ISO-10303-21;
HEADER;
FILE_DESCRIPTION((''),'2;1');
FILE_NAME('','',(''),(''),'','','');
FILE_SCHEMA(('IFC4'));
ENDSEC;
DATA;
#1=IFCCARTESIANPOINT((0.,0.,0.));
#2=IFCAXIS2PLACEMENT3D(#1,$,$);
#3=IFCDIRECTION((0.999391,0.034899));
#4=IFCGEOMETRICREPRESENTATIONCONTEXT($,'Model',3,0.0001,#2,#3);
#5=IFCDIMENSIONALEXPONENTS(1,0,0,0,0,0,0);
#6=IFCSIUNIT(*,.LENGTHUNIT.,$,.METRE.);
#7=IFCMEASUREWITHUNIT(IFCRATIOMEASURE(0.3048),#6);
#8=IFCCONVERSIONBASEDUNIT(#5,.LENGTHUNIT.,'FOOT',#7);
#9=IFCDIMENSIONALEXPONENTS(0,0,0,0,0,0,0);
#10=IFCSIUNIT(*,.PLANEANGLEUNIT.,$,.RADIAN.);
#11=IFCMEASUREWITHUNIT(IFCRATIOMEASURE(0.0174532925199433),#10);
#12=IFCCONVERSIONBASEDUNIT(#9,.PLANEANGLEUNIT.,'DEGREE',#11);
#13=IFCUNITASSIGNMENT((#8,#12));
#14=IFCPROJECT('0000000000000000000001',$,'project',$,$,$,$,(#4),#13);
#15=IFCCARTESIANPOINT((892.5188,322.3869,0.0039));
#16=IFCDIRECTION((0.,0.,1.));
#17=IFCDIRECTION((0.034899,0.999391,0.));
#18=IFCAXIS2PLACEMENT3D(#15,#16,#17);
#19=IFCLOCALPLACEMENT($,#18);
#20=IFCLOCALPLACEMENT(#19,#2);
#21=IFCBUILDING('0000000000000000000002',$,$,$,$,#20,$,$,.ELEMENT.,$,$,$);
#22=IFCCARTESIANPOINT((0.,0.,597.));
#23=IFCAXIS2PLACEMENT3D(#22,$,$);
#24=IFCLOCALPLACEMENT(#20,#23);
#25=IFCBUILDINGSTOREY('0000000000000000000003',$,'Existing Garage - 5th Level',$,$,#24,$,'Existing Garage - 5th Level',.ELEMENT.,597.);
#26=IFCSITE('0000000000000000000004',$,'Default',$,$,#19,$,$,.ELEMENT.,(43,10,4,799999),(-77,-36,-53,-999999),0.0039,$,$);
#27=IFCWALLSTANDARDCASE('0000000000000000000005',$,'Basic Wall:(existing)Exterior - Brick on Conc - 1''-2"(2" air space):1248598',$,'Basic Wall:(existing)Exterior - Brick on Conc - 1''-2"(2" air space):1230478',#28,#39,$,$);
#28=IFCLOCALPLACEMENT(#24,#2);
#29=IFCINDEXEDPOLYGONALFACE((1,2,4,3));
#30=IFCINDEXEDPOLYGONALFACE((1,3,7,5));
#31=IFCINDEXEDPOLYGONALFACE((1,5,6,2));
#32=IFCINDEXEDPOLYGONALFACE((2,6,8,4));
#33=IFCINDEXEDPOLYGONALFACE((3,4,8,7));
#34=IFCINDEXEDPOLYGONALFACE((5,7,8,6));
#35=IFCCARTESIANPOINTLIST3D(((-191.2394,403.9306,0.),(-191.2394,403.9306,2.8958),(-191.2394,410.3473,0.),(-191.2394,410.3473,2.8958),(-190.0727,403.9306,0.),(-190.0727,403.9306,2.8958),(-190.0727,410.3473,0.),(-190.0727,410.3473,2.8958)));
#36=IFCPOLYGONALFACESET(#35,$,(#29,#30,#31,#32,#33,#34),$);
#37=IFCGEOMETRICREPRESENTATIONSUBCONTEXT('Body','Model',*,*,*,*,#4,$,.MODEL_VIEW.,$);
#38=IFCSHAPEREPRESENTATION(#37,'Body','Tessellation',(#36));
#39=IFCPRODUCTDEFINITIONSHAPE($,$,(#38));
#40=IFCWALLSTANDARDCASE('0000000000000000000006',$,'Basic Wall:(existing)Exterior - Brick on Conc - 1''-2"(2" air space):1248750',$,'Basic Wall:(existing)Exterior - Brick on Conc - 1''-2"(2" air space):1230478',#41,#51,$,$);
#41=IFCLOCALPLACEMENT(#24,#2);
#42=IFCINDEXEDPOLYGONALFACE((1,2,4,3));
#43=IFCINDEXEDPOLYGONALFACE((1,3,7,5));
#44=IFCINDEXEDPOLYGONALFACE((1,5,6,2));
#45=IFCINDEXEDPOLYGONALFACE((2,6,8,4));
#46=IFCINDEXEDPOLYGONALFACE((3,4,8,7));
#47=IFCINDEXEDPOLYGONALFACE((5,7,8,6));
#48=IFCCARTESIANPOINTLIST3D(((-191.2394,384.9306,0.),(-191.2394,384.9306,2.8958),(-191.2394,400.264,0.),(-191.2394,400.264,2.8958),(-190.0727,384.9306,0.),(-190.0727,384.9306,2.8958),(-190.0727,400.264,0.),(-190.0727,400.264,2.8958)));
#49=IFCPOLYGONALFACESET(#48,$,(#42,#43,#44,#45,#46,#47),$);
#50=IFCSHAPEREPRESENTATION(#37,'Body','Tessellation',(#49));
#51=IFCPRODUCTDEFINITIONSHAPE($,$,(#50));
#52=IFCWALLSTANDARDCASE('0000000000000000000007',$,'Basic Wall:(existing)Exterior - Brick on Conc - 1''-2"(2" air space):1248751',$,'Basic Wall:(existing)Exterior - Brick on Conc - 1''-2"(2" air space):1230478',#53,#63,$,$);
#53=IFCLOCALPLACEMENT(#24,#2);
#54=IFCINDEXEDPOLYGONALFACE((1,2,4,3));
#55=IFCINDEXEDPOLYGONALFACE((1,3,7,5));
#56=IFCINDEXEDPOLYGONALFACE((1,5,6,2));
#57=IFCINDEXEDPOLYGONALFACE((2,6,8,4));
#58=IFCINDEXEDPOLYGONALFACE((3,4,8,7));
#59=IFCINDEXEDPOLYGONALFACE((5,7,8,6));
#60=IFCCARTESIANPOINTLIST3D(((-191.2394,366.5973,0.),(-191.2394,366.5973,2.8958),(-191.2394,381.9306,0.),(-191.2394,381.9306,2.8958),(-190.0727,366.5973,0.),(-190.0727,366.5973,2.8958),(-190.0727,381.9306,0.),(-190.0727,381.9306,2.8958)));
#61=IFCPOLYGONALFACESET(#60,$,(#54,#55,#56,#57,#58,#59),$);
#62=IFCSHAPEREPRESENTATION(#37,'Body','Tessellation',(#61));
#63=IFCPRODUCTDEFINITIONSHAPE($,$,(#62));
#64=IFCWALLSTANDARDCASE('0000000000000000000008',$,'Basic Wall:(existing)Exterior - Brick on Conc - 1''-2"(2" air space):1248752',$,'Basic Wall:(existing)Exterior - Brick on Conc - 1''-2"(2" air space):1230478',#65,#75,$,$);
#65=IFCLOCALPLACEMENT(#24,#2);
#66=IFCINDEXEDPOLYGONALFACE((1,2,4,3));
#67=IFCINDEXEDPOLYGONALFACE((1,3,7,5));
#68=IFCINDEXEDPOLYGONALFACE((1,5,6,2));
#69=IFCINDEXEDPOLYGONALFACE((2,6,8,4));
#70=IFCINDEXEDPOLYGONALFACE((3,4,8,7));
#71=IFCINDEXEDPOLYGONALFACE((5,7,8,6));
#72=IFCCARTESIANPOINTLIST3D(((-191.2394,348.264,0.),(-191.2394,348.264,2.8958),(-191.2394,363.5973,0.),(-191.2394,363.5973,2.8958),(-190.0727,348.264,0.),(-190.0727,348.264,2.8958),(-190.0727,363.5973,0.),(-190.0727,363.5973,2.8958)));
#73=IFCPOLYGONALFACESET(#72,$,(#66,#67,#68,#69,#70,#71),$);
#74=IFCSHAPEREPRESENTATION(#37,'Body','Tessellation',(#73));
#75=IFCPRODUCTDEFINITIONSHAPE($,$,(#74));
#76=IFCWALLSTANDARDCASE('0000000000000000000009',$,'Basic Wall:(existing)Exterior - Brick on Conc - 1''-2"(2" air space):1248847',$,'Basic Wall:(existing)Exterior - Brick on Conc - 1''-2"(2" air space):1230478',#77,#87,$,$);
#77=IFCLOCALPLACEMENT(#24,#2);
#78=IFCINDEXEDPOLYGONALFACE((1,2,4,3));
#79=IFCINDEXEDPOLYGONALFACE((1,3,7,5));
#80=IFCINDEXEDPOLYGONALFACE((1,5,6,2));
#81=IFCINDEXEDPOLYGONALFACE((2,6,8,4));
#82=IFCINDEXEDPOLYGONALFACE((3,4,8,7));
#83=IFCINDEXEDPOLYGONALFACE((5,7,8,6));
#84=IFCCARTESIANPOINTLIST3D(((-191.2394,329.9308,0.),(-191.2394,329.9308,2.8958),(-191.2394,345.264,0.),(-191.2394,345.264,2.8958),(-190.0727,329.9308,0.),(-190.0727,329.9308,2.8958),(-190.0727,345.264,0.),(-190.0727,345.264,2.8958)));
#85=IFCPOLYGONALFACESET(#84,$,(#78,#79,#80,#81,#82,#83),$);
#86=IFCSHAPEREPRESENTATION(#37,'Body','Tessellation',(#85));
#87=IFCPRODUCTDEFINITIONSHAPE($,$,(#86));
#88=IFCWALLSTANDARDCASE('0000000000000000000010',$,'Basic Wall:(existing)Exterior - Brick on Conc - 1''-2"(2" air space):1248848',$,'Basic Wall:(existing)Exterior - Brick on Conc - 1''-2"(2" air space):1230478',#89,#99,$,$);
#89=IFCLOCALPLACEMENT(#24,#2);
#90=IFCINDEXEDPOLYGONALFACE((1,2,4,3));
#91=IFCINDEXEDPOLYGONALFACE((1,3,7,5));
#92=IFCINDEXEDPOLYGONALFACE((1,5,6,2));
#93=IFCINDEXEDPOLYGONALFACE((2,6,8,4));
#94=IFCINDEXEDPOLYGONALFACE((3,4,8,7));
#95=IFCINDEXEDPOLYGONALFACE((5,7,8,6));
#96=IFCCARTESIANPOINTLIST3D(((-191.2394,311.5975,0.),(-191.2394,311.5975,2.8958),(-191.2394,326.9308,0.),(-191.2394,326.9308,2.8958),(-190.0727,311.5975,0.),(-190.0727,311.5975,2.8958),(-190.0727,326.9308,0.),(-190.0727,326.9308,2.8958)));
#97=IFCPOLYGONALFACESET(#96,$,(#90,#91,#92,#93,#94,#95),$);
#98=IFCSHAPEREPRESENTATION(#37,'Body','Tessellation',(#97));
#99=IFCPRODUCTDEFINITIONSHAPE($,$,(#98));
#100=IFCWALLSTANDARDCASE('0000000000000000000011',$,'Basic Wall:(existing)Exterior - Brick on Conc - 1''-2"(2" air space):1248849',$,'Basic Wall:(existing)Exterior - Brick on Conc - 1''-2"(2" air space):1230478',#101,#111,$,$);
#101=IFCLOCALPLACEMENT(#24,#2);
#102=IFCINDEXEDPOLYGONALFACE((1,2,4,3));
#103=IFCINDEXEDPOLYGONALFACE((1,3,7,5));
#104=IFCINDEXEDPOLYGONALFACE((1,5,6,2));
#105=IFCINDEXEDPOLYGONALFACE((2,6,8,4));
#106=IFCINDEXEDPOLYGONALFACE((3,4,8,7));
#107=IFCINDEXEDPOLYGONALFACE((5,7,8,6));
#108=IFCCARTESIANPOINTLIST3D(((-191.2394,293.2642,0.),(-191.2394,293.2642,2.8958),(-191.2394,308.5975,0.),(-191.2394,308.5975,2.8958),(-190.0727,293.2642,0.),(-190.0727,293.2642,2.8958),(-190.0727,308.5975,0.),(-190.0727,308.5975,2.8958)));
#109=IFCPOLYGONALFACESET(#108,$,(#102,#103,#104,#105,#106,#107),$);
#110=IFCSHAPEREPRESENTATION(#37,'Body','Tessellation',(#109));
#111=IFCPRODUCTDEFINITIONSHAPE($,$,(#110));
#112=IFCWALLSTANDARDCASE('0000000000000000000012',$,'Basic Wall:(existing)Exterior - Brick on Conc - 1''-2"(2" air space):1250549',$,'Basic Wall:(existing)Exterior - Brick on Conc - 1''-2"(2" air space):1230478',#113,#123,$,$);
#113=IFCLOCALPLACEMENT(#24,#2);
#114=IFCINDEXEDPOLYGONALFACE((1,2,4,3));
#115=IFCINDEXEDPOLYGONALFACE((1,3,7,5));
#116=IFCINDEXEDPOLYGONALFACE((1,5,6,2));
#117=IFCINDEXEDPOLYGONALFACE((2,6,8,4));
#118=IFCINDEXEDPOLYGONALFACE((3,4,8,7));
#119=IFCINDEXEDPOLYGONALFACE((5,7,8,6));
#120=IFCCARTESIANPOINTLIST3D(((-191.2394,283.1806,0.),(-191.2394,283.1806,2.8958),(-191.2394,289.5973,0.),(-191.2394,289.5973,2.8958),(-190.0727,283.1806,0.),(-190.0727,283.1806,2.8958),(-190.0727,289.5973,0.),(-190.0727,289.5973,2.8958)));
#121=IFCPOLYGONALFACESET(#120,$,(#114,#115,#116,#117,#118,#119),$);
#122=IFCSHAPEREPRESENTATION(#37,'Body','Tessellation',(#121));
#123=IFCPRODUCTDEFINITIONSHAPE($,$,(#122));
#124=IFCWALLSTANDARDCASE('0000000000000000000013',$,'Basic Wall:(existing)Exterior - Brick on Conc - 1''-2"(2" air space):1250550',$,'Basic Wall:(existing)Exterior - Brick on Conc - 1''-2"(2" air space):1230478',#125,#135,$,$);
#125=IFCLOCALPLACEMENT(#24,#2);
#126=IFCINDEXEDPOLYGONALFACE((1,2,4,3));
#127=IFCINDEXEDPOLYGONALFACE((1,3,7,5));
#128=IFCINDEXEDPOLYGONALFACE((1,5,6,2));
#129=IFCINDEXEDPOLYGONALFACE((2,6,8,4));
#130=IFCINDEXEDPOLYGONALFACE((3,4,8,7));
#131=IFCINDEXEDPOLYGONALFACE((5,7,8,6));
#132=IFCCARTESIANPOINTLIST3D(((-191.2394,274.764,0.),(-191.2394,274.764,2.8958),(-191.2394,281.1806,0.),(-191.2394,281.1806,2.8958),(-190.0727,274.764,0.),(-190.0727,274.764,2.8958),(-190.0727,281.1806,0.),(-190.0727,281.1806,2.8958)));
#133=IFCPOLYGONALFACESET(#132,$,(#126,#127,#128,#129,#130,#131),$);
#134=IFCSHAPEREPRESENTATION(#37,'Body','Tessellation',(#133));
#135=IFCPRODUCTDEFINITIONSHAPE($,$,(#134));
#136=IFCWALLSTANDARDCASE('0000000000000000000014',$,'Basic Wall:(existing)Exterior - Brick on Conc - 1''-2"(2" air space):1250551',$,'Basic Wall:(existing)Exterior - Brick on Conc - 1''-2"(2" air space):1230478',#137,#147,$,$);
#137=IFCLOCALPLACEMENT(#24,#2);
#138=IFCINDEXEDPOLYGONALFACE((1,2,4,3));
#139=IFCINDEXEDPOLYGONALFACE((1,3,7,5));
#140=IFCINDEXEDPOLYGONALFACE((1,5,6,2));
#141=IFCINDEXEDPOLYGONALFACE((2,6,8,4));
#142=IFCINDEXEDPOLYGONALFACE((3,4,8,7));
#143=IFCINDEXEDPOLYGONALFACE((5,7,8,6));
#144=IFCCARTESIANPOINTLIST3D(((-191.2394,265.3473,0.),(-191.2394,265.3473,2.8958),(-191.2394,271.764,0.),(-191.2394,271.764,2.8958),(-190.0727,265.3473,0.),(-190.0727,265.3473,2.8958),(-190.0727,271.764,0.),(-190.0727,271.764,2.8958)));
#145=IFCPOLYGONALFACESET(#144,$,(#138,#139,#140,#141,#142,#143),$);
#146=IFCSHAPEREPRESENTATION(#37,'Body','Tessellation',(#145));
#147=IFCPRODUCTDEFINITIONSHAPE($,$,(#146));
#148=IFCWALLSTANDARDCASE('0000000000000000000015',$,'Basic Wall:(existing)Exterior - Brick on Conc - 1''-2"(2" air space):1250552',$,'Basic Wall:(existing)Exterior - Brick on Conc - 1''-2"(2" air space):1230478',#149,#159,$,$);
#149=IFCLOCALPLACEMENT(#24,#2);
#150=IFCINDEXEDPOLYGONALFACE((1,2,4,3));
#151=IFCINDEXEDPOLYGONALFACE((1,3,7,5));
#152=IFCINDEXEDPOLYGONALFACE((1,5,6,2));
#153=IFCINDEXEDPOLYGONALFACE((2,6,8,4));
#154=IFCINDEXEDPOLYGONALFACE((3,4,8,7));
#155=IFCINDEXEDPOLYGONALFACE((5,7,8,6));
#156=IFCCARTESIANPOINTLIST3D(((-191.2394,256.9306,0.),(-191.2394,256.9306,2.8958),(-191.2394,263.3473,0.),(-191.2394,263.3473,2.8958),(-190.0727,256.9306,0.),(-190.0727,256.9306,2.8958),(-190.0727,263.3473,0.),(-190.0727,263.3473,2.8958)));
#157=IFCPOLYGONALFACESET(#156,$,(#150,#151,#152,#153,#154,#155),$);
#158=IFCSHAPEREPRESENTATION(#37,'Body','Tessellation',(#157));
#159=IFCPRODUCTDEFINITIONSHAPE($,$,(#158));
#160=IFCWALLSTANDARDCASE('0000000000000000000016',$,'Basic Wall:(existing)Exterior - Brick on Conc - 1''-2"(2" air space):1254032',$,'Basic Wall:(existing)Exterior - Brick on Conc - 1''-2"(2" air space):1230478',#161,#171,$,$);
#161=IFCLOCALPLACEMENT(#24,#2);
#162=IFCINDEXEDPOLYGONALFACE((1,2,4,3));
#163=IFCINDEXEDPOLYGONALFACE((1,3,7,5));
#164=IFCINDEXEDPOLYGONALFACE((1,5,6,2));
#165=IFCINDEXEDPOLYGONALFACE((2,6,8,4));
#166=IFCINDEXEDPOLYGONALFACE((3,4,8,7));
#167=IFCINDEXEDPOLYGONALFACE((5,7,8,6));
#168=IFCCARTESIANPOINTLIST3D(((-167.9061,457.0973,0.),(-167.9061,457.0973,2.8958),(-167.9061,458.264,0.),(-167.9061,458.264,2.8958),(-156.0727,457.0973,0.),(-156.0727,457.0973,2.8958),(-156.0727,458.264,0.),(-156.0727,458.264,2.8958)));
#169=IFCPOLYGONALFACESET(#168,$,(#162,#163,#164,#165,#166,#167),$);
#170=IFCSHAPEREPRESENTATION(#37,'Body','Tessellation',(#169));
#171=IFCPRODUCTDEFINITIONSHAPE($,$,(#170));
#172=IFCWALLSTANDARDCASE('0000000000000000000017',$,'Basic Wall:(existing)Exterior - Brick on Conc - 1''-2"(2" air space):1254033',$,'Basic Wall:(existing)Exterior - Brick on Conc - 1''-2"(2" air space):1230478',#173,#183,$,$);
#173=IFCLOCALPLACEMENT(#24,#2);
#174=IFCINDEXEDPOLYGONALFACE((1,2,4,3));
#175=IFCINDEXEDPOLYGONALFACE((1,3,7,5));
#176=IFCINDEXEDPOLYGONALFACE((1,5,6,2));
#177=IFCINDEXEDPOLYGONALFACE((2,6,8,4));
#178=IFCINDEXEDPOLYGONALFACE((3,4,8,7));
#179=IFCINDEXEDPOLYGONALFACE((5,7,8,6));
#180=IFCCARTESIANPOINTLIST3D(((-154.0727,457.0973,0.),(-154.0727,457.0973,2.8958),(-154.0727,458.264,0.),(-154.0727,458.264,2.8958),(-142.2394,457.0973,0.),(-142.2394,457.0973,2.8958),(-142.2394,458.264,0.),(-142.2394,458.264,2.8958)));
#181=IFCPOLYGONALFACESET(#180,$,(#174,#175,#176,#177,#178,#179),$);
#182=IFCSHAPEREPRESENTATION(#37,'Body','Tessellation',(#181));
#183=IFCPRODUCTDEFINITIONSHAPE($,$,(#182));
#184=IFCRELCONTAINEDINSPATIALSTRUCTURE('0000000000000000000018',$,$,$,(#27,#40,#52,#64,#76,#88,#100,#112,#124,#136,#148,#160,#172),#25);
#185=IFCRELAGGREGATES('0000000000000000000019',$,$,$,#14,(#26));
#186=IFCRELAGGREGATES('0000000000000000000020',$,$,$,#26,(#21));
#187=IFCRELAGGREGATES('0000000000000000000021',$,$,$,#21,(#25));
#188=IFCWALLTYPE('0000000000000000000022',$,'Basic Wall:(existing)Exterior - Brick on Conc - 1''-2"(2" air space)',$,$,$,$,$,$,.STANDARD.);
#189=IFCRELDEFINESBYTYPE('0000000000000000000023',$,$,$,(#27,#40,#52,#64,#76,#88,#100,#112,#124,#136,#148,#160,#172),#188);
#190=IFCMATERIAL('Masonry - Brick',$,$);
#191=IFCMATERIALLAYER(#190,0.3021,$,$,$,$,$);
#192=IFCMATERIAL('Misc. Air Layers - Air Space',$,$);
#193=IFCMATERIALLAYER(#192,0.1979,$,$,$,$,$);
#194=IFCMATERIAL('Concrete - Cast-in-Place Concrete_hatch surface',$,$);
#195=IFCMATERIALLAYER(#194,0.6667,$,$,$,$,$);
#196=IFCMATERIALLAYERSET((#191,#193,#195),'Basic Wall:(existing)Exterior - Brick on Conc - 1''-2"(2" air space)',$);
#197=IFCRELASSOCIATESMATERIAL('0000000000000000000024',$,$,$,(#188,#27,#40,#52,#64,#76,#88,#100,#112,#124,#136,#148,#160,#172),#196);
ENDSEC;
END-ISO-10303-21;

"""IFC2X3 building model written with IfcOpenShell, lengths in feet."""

from ifc_helpers import new_model, entity, si_unit, converted_unit, direction, frame, frame_2d, origin, place, context, subcontext, project, spatial, rectangle, extrude, material, layer, layer_set, layer_usage, type_object, element, save


model = new_model("IFC2X3")

# Units and contexts
model_context = context("Model", 3, precision=0.0001, world=origin(), true_north=direction((0.999391, 0.034899)))
body_context = subcontext(model_context, "Body", "Model", "MODEL_VIEW")
ifc_project = project(units=[converted_unit("LENGTHUNIT", "FOOT", entity("IfcRatioMeasure", 0.3048), si_unit("LENGTHUNIT", "METRE"), dimensions=[1, 0, 0, 0, 0, 0, 0]), converted_unit("PLANEANGLEUNIT", "DEGREE", entity("IfcRatioMeasure", 0.0174532925199433), si_unit("PLANEANGLEUNIT", "RADIAN"), dimensions=[0, 0, 0, 0, 0, 0, 0])], contexts=[model_context])

# Site, building, storey
site_placement = place(None, frame((892.5188, 322.3869, 0.0039), z_axis=(0.0, 0.0, 1.0), x_axis=(0.034899, 0.999391, 0.0)))
site = spatial("IfcSite", under=ifc_project, at=site_placement, Name="Default", CompositionType="ELEMENT", RefLatitude=(43, 10, 4, 799999), RefLongitude=(-77, -36, -53, -999999), RefElevation=0.0039)
building_placement = place(site_placement, origin())
building = spatial("IfcBuilding", under=site, at=building_placement, CompositionType="ELEMENT")
storey_placement = place(building_placement, frame((0.0, 0.0, 597.0)))
storey = spatial("IfcBuildingStorey", under=building, at=storey_placement, Name="Existing Garage - 5th Level", LongName="Existing Garage - 5th Level", CompositionType="ELEMENT", Elevation=597.0)

# Walls
ifc_material_1 = material(Name="Masonry - Brick")
ifc_layer_1 = layer(ifc_material_1, 0.3021)
ifc_material_2 = material(Name="Misc. Air Layers - Air Space")
ifc_layer_2 = layer(ifc_material_2, 0.1979)
ifc_material_3 = material(Name="Concrete - Cast-in-Place Concrete_hatch surface")
ifc_layer_3 = layer(ifc_material_3, 0.6667)
ifc_layer_set_1 = layer_set([ifc_layer_1, ifc_layer_2, ifc_layer_3], Name="Basic Wall:(existing)Exterior - Brick on Conc - 1'-2\"(2\" air space)")
wall_type_1 = type_object("IfcWallType", Name="Basic Wall:(existing)Exterior - Brick on Conc - 1'-2\"(2\" air space)", PredefinedType="STANDARD", material=ifc_layer_set_1)
ifc_layer_usage_1 = layer_usage(ifc_layer_set_1, "AXIS2", "POSITIVE", -0.5833)
wall_1_placement = place(storey_placement, frame((-190.6561, 410.3473, 0.0), z_axis=(0.0, 0.0, 1.0), x_axis=(0.0, -1.0, 0.0)))
element("IfcWallStandardCase", 1, at=wall_1_placement, inside=storey, type_object=wall_type_1, material=ifc_layer_usage_1, Name="Basic Wall:(existing)Exterior - Brick on Conc - 1'-2\"(2\" air space):1248598", ObjectType="Basic Wall:(existing)Exterior - Brick on Conc - 1'-2\"(2\" air space):1230478", context=body_context, shape_type="SweptSolid", body=[
    extrude(rectangle(XDim=6.4167, YDim=1.1667, at=frame_2d((3.2084, 0.0), x_axis=(-1.0, 0.0))), origin(), (0.0, 0.0, 1.0), 2.8958),
])
ifc_layer_usage_2 = layer_usage(ifc_layer_set_1, "AXIS2", "POSITIVE", -0.5833)
wall_2_placement = place(storey_placement, frame((-190.6561, 400.264, 0.0), z_axis=(0.0, 0.0, 1.0), x_axis=(0.0, -1.0, 0.0)))
element("IfcWallStandardCase", 2, at=wall_2_placement, inside=storey, type_object=wall_type_1, material=ifc_layer_usage_2, Name="Basic Wall:(existing)Exterior - Brick on Conc - 1'-2\"(2\" air space):1248750", ObjectType="Basic Wall:(existing)Exterior - Brick on Conc - 1'-2\"(2\" air space):1230478", context=body_context, shape_type="SweptSolid", body=[
    extrude(rectangle(XDim=15.3333, YDim=1.1667, at=frame_2d((7.6667, 0.0), x_axis=(-1.0, 0.0))), origin(), (0.0, 0.0, 1.0), 2.8958),
])
ifc_layer_usage_3 = layer_usage(ifc_layer_set_1, "AXIS2", "POSITIVE", -0.5833)
wall_3_placement = place(storey_placement, frame((-190.6561, 381.9306, 0.0), z_axis=(0.0, 0.0, 1.0), x_axis=(0.0, -1.0, 0.0)))
element("IfcWallStandardCase", 3, at=wall_3_placement, inside=storey, type_object=wall_type_1, material=ifc_layer_usage_3, Name="Basic Wall:(existing)Exterior - Brick on Conc - 1'-2\"(2\" air space):1248751", ObjectType="Basic Wall:(existing)Exterior - Brick on Conc - 1'-2\"(2\" air space):1230478", context=body_context, shape_type="SweptSolid", body=[
    extrude(rectangle(XDim=15.3333, YDim=1.1667, at=frame_2d((7.6667, 0.0), x_axis=(-1.0, 0.0))), origin(), (0.0, 0.0, 1.0), 2.8958),
])
ifc_layer_usage_4 = layer_usage(ifc_layer_set_1, "AXIS2", "POSITIVE", -0.5833)
wall_4_placement = place(storey_placement, frame((-190.6561, 363.5973, 0.0), z_axis=(0.0, 0.0, 1.0), x_axis=(0.0, -1.0, 0.0)))
element("IfcWallStandardCase", 4, at=wall_4_placement, inside=storey, type_object=wall_type_1, material=ifc_layer_usage_4, Name="Basic Wall:(existing)Exterior - Brick on Conc - 1'-2\"(2\" air space):1248752", ObjectType="Basic Wall:(existing)Exterior - Brick on Conc - 1'-2\"(2\" air space):1230478", context=body_context, shape_type="SweptSolid", body=[
    extrude(rectangle(XDim=15.3333, YDim=1.1667, at=frame_2d((7.6667, 0.0), x_axis=(-1.0, 0.0))), origin(), (0.0, 0.0, 1.0), 2.8958),
])
ifc_layer_usage_5 = layer_usage(ifc_layer_set_1, "AXIS2", "POSITIVE", -0.5833)
wall_5_placement = place(storey_placement, frame((-190.6561, 345.264, 0.0), z_axis=(0.0, 0.0, 1.0), x_axis=(0.0, -1.0, 0.0)))
element("IfcWallStandardCase", 5, at=wall_5_placement, inside=storey, type_object=wall_type_1, material=ifc_layer_usage_5, Name="Basic Wall:(existing)Exterior - Brick on Conc - 1'-2\"(2\" air space):1248847", ObjectType="Basic Wall:(existing)Exterior - Brick on Conc - 1'-2\"(2\" air space):1230478", context=body_context, shape_type="SweptSolid", body=[
    extrude(rectangle(XDim=15.3331, YDim=1.1667, at=frame_2d((7.6666, 0.0), x_axis=(-1.0, 0.0))), origin(), (0.0, 0.0, 1.0), 2.8958),
])
ifc_layer_usage_6 = layer_usage(ifc_layer_set_1, "AXIS2", "POSITIVE", -0.5833)
wall_6_placement = place(storey_placement, frame((-190.6561, 326.9308, 0.0), z_axis=(0.0, 0.0, 1.0), x_axis=(0.0, -1.0, 0.0)))
element("IfcWallStandardCase", 6, at=wall_6_placement, inside=storey, type_object=wall_type_1, material=ifc_layer_usage_6, Name="Basic Wall:(existing)Exterior - Brick on Conc - 1'-2\"(2\" air space):1248848", ObjectType="Basic Wall:(existing)Exterior - Brick on Conc - 1'-2\"(2\" air space):1230478", context=body_context, shape_type="SweptSolid", body=[
    extrude(rectangle(XDim=15.3333, YDim=1.1667, at=frame_2d((7.6667, 0.0), x_axis=(-1.0, 0.0))), origin(), (0.0, 0.0, 1.0), 2.8958),
])
ifc_layer_usage_7 = layer_usage(ifc_layer_set_1, "AXIS2", "POSITIVE", -0.5833)
wall_7_placement = place(storey_placement, frame((-190.6561, 308.5975, 0.0), z_axis=(0.0, 0.0, 1.0), x_axis=(0.0, -1.0, 0.0)))
element("IfcWallStandardCase", 7, at=wall_7_placement, inside=storey, type_object=wall_type_1, material=ifc_layer_usage_7, Name="Basic Wall:(existing)Exterior - Brick on Conc - 1'-2\"(2\" air space):1248849", ObjectType="Basic Wall:(existing)Exterior - Brick on Conc - 1'-2\"(2\" air space):1230478", context=body_context, shape_type="SweptSolid", body=[
    extrude(rectangle(XDim=15.3333, YDim=1.1667, at=frame_2d((7.6667, 0.0), x_axis=(-1.0, 0.0))), origin(), (0.0, 0.0, 1.0), 2.8958),
])
ifc_layer_usage_8 = layer_usage(ifc_layer_set_1, "AXIS2", "POSITIVE", -0.5833)
wall_8_placement = place(storey_placement, frame((-190.6561, 289.5973, 0.0), z_axis=(0.0, 0.0, 1.0), x_axis=(0.0, -1.0, 0.0)))
element("IfcWallStandardCase", 8, at=wall_8_placement, inside=storey, type_object=wall_type_1, material=ifc_layer_usage_8, Name="Basic Wall:(existing)Exterior - Brick on Conc - 1'-2\"(2\" air space):1250549", ObjectType="Basic Wall:(existing)Exterior - Brick on Conc - 1'-2\"(2\" air space):1230478", context=body_context, shape_type="SweptSolid", body=[
    extrude(rectangle(XDim=6.4167, YDim=1.1667, at=frame_2d((3.2083, 0.0), x_axis=(-1.0, 0.0))), origin(), (0.0, 0.0, 1.0), 2.8958),
])
ifc_layer_usage_9 = layer_usage(ifc_layer_set_1, "AXIS2", "POSITIVE", -0.5833)
wall_9_placement = place(storey_placement, frame((-190.6561, 281.1806, 0.0), z_axis=(0.0, 0.0, 1.0), x_axis=(0.0, -1.0, 0.0)))
element("IfcWallStandardCase", 9, at=wall_9_placement, inside=storey, type_object=wall_type_1, material=ifc_layer_usage_9, Name="Basic Wall:(existing)Exterior - Brick on Conc - 1'-2\"(2\" air space):1250550", ObjectType="Basic Wall:(existing)Exterior - Brick on Conc - 1'-2\"(2\" air space):1230478", context=body_context, shape_type="SweptSolid", body=[
    extrude(rectangle(XDim=6.4167, YDim=1.1667, at=frame_2d((3.2083, 0.0), x_axis=(-1.0, 0.0))), origin(), (0.0, 0.0, 1.0), 2.8958),
])
ifc_layer_usage_10 = layer_usage(ifc_layer_set_1, "AXIS2", "POSITIVE", -0.5833)
wall_10_placement = place(storey_placement, frame((-190.6561, 271.764, 0.0), z_axis=(0.0, 0.0, 1.0), x_axis=(0.0, -1.0, 0.0)))
element("IfcWallStandardCase", 10, at=wall_10_placement, inside=storey, type_object=wall_type_1, material=ifc_layer_usage_10, Name="Basic Wall:(existing)Exterior - Brick on Conc - 1'-2\"(2\" air space):1250551", ObjectType="Basic Wall:(existing)Exterior - Brick on Conc - 1'-2\"(2\" air space):1230478", context=body_context, shape_type="SweptSolid", body=[
    extrude(rectangle(XDim=6.4167, YDim=1.1667, at=frame_2d((3.2083, 0.0), x_axis=(-1.0, 0.0))), origin(), (0.0, 0.0, 1.0), 2.8958),
])
ifc_layer_usage_11 = layer_usage(ifc_layer_set_1, "AXIS2", "POSITIVE", -0.5833)
wall_11_placement = place(storey_placement, frame((-190.6561, 263.3473, 0.0), z_axis=(0.0, 0.0, 1.0), x_axis=(0.0, -1.0, 0.0)))
element("IfcWallStandardCase", 11, at=wall_11_placement, inside=storey, type_object=wall_type_1, material=ifc_layer_usage_11, Name="Basic Wall:(existing)Exterior - Brick on Conc - 1'-2\"(2\" air space):1250552", ObjectType="Basic Wall:(existing)Exterior - Brick on Conc - 1'-2\"(2\" air space):1230478", context=body_context, shape_type="SweptSolid", body=[
    extrude(rectangle(XDim=6.4167, YDim=1.1667, at=frame_2d((3.2083, 0.0), x_axis=(-1.0, 0.0))), origin(), (0.0, 0.0, 1.0), 2.8958),
])
ifc_layer_usage_12 = layer_usage(ifc_layer_set_1, "AXIS2", "POSITIVE", -0.5833)
wall_12_placement = place(storey_placement, frame((-156.0727, 457.6806, 0.0), z_axis=(0.0, 0.0, 1.0), x_axis=(-1.0, 0.0, 0.0)))
element("IfcWallStandardCase", 12, at=wall_12_placement, inside=storey, type_object=wall_type_1, material=ifc_layer_usage_12, Name="Basic Wall:(existing)Exterior - Brick on Conc - 1'-2\"(2\" air space):1254032", ObjectType="Basic Wall:(existing)Exterior - Brick on Conc - 1'-2\"(2\" air space):1230478", context=body_context, shape_type="SweptSolid", body=[
    extrude(rectangle(XDim=11.8333, YDim=1.1667, at=frame_2d((5.9167, 0.0), x_axis=(-1.0, 0.0))), origin(), (0.0, 0.0, 1.0), 2.8958),
])
ifc_layer_usage_13 = layer_usage(ifc_layer_set_1, "AXIS2", "NEGATIVE", 0.5833)
wall_13_placement = place(storey_placement, frame((-154.0727, 457.6806, 0.0)))
element("IfcWallStandardCase", 13, at=wall_13_placement, inside=storey, type_object=wall_type_1, material=ifc_layer_usage_13, Name="Basic Wall:(existing)Exterior - Brick on Conc - 1'-2\"(2\" air space):1254033", ObjectType="Basic Wall:(existing)Exterior - Brick on Conc - 1'-2\"(2\" air space):1230478", context=body_context, shape_type="SweptSolid", body=[
    extrude(rectangle(XDim=11.8333, YDim=1.1667, at=frame_2d((5.9167, 0.0), x_axis=(-1.0, 0.0))), origin(), (0.0, 0.0, 1.0), 2.8958),
])

save(model, "model.ifc")
